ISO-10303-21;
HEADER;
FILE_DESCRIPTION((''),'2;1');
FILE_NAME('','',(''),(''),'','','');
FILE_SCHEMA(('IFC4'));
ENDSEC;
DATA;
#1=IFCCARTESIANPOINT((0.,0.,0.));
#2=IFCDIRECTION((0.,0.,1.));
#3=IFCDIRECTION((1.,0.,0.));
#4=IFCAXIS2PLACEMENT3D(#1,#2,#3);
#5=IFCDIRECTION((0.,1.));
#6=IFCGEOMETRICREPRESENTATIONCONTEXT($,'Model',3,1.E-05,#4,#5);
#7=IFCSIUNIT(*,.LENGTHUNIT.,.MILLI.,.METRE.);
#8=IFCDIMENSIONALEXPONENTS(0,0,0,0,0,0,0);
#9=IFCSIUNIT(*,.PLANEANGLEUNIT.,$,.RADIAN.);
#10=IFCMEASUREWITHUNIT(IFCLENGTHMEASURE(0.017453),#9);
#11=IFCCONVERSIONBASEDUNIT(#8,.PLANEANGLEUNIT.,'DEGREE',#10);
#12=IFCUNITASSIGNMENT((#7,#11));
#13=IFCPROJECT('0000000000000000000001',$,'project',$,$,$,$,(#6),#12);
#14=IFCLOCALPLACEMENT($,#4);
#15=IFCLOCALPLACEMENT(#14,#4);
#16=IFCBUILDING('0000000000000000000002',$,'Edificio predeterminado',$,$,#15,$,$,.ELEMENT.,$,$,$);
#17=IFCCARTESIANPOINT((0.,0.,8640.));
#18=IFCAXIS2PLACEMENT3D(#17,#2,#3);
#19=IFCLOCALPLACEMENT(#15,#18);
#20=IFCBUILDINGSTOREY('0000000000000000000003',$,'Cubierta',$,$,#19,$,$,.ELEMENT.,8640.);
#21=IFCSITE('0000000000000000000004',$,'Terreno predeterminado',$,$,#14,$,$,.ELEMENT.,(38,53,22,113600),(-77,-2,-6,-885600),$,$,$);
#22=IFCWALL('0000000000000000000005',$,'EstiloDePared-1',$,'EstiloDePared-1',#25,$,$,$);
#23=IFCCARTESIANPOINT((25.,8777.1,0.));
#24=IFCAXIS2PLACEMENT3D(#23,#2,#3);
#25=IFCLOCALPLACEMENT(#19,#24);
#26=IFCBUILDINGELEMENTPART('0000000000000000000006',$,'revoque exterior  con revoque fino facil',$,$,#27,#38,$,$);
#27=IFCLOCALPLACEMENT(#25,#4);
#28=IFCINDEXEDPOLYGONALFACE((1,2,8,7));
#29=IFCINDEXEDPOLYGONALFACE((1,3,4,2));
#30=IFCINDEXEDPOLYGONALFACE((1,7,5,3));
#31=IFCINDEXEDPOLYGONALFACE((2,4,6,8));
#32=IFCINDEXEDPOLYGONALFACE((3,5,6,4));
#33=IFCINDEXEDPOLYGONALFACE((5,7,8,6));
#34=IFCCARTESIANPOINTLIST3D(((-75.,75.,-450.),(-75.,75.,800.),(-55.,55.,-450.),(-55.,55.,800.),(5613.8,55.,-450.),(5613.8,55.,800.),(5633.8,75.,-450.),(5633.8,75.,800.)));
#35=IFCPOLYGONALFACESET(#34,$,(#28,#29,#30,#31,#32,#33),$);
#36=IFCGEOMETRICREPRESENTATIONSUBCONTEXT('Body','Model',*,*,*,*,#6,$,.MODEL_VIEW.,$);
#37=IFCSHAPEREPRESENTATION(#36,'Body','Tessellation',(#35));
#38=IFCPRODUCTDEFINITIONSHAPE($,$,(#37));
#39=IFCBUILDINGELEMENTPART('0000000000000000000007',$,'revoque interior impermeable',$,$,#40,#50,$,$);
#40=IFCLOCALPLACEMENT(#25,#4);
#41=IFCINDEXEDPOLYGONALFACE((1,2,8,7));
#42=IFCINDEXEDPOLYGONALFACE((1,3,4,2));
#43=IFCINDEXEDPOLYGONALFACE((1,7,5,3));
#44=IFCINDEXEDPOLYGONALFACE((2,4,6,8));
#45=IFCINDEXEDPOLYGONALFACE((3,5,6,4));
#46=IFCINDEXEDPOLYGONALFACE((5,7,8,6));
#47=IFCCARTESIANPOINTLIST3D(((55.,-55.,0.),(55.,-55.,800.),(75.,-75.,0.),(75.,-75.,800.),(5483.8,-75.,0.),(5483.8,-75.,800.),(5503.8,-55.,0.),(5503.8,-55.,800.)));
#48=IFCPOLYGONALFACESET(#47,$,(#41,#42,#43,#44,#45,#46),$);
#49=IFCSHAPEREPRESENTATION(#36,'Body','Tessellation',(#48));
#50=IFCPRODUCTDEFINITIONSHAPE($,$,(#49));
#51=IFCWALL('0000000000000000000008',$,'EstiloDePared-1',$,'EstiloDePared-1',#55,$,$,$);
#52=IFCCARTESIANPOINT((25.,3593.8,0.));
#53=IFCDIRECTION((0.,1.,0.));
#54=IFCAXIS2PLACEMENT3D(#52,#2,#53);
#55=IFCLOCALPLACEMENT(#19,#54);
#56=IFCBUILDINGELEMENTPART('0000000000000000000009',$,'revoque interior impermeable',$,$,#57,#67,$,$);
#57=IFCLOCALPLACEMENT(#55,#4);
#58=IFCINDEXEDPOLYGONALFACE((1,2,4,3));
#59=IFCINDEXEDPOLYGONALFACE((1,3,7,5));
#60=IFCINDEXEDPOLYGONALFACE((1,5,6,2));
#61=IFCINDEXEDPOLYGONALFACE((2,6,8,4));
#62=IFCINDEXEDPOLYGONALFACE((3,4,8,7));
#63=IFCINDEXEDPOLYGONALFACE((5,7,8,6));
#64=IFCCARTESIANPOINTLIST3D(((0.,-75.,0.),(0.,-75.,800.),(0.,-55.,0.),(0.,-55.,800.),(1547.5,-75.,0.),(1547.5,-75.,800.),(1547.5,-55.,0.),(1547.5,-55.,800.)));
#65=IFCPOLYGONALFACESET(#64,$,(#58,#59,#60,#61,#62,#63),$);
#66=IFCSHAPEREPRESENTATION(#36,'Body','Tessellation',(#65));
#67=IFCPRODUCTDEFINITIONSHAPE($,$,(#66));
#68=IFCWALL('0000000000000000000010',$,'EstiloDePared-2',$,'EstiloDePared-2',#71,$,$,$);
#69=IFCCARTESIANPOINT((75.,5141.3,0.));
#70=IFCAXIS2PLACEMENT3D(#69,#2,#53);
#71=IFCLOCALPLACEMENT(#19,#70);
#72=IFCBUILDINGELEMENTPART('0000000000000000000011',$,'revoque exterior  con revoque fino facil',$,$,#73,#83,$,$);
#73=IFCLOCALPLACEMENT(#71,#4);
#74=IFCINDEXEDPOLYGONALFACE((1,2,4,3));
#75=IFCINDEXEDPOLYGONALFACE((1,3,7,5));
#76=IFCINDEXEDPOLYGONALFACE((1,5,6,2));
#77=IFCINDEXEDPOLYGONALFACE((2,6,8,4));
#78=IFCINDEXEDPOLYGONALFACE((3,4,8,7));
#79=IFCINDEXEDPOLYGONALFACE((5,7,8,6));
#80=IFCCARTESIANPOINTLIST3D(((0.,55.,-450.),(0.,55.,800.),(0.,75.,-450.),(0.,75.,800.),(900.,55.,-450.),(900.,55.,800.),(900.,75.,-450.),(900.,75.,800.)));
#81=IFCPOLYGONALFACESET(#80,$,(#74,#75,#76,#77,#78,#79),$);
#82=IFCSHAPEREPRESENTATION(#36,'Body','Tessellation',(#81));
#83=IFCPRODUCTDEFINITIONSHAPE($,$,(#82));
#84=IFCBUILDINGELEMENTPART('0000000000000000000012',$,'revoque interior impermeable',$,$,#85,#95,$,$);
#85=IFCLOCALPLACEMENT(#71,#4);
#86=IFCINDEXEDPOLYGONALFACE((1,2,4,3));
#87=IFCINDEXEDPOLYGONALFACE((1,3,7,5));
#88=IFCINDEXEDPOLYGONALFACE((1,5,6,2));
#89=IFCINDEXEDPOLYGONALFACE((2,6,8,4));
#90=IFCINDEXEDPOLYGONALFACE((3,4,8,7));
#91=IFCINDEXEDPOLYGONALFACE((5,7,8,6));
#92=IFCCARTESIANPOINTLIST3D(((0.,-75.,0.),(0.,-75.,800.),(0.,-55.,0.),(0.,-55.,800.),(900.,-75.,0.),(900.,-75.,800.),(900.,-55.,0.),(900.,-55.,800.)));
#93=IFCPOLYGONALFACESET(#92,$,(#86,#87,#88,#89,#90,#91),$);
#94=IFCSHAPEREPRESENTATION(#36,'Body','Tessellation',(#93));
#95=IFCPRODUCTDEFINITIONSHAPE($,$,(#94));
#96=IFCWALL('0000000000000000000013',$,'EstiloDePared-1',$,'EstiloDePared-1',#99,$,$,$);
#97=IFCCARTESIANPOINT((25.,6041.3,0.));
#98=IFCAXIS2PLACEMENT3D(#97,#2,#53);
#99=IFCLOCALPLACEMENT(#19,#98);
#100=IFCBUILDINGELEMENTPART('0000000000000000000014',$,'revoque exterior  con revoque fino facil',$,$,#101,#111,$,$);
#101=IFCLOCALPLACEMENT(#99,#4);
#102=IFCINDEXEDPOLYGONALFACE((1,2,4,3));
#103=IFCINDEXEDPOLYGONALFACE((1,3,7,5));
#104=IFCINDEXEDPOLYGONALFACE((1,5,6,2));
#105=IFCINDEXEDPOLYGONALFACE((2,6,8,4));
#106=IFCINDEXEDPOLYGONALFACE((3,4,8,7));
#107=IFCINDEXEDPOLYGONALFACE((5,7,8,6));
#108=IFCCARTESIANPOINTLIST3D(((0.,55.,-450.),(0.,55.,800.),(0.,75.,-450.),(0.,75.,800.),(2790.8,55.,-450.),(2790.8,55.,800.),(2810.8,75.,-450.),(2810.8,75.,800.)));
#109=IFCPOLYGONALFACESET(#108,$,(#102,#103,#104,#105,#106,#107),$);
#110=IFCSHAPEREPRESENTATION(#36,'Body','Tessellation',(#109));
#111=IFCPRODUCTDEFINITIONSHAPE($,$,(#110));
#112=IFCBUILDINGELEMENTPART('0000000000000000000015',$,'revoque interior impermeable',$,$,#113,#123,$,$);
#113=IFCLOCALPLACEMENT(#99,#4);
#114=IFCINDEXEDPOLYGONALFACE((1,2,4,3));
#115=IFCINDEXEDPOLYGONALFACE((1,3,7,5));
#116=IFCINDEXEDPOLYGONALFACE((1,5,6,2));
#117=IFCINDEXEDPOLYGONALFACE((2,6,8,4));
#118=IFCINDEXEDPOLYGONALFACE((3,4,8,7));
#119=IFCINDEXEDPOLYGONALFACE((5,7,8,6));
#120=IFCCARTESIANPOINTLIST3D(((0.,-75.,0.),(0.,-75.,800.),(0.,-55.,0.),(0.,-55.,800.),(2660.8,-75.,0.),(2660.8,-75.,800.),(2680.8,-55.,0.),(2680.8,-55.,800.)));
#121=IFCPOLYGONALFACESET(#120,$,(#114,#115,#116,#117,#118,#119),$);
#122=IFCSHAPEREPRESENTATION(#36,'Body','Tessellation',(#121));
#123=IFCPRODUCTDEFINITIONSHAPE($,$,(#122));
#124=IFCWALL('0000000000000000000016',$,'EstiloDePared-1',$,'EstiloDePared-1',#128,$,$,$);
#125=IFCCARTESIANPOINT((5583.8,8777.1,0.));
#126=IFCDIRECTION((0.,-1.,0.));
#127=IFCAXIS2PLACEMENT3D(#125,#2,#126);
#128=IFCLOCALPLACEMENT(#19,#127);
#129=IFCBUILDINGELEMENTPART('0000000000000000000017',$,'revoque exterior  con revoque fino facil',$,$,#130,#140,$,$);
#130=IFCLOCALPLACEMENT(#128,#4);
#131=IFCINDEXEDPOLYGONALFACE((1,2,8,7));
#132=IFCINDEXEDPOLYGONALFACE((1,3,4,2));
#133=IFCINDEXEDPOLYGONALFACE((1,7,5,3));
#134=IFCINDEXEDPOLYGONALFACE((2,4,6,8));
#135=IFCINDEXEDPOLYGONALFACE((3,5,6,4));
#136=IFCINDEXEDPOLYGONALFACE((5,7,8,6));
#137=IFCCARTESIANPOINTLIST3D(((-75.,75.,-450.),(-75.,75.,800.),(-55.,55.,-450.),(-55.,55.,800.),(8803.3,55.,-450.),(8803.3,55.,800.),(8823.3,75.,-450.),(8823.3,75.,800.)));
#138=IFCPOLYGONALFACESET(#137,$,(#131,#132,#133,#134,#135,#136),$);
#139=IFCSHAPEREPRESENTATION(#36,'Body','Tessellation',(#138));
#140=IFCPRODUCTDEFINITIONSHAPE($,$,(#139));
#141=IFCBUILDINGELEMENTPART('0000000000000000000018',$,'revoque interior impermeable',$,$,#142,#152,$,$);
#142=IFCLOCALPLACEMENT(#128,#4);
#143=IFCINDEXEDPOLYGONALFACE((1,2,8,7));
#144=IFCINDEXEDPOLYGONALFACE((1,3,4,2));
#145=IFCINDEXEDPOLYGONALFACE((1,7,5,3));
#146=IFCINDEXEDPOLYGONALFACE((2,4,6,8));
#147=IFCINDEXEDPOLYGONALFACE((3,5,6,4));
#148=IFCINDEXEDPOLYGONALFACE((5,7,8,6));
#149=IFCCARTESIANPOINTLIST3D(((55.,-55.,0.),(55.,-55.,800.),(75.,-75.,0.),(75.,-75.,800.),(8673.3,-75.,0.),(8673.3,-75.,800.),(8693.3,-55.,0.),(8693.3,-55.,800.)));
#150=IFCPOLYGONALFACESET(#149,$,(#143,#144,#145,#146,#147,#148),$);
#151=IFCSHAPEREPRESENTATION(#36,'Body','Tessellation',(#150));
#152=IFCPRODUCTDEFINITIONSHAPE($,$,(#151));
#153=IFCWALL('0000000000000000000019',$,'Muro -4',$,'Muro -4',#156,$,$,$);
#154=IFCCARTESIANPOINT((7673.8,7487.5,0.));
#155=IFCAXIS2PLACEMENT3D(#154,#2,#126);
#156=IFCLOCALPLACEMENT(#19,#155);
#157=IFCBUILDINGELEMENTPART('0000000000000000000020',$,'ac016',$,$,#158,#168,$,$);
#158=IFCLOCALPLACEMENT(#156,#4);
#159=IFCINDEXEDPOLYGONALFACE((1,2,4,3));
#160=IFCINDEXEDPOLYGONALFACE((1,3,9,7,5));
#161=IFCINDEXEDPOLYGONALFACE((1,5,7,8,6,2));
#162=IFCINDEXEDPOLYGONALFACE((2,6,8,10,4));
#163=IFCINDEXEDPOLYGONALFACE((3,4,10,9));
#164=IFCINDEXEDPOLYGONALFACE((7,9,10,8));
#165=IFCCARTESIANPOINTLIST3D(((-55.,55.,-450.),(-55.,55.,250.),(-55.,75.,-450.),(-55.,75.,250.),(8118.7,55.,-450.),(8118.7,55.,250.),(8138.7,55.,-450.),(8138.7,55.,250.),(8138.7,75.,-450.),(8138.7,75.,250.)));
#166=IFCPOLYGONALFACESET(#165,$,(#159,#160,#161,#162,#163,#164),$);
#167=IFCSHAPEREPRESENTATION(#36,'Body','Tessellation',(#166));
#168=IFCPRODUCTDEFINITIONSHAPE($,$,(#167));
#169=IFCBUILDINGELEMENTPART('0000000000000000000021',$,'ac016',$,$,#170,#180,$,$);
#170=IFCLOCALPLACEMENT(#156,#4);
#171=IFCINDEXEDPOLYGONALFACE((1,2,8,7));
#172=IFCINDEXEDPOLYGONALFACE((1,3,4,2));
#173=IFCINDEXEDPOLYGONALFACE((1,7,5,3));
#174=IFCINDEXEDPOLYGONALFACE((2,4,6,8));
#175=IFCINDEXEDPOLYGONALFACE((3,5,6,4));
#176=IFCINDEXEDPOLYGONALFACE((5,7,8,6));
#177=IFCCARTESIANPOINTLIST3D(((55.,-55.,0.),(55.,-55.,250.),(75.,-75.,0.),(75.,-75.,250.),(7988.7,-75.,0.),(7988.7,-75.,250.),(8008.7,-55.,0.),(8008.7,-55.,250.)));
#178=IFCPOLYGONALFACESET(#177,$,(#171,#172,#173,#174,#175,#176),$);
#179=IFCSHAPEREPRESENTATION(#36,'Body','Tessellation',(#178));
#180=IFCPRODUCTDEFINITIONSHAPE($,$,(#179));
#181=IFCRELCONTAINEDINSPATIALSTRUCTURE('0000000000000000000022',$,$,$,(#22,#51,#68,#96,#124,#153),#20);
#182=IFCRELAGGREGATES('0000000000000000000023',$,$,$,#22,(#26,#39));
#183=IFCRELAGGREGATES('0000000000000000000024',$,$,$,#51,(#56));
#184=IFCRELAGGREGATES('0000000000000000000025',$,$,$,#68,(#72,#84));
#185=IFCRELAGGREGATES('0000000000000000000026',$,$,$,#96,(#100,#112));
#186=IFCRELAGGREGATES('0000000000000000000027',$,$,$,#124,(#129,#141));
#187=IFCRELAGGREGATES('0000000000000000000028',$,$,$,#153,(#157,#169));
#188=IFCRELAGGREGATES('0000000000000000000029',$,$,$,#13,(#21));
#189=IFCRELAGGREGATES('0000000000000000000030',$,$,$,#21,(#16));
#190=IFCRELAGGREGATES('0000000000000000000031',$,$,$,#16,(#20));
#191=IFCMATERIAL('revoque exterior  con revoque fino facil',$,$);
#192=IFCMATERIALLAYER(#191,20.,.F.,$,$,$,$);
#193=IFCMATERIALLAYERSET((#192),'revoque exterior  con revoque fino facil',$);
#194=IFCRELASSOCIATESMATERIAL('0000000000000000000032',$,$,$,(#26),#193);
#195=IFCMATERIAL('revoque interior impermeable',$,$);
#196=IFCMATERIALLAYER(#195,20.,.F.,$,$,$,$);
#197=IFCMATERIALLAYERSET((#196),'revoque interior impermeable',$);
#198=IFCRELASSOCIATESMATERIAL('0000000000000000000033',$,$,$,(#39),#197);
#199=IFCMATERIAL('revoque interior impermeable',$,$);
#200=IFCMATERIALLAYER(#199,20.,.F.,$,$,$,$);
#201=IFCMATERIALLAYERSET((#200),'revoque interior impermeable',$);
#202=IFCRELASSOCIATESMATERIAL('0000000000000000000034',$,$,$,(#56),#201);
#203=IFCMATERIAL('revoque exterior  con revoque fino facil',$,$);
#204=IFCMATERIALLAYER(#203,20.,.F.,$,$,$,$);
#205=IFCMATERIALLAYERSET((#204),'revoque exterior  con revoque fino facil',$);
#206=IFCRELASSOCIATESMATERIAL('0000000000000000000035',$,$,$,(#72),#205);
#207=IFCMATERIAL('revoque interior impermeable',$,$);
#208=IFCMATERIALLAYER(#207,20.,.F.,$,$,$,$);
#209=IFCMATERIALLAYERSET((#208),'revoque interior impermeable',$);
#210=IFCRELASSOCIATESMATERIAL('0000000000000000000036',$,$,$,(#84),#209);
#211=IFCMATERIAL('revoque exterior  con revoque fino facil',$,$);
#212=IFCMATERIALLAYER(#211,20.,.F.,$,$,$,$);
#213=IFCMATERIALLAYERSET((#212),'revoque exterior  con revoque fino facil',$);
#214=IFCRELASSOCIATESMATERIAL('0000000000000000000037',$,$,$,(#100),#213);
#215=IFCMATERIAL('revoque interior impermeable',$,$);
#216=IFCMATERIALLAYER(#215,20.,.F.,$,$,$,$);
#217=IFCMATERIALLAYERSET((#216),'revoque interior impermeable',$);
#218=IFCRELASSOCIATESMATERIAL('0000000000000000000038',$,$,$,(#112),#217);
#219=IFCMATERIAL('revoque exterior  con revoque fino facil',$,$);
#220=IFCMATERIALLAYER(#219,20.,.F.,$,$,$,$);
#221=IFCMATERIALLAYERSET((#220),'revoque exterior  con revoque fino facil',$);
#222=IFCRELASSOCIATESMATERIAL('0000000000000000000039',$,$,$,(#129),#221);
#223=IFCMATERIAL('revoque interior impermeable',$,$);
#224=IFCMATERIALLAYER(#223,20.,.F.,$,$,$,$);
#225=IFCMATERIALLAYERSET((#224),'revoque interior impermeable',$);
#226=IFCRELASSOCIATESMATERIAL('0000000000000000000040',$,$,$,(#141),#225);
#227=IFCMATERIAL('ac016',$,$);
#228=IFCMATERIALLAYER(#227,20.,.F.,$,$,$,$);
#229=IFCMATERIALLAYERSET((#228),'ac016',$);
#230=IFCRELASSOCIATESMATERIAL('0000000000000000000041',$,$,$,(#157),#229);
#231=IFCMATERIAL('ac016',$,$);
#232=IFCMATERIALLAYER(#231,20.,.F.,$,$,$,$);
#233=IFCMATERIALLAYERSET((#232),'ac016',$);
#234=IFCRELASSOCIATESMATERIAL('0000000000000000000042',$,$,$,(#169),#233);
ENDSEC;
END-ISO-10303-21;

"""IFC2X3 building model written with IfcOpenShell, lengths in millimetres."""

from ifc_helpers import new_model, entity, si_unit, converted_unit, direction, frame, origin_with_axes, place, context, subcontext, project, spatial, polyline, outline, extrude, material, layer, layer_set, layer_usage, element, aggregate, save


model = new_model("IFC2X3")

# Units and contexts
model_context = context("Model", 3, precision=1e-05, world=origin_with_axes(), true_north=direction((0.0, 1.0)))
body_context = subcontext(model_context, "Body", "Model", "MODEL_VIEW")
ifc_project = project(units=[si_unit("LENGTHUNIT", "METRE", prefix="MILLI"), converted_unit("PLANEANGLEUNIT", "DEGREE", entity("IfcLengthMeasure", 0.017453), si_unit("PLANEANGLEUNIT", "RADIAN"), dimensions=[0, 0, 0, 0, 0, 0, 0])], contexts=[model_context])

# Site, building, storey
site_placement = place(None, origin_with_axes())
site = spatial("IfcSite", under=ifc_project, at=site_placement, Name="Terreno predeterminado", CompositionType="ELEMENT", RefLatitude=(38, 53, 22, 113600), RefLongitude=(-77, -2, -6, -885600))
building_placement = place(site_placement, origin_with_axes())
building = spatial("IfcBuilding", under=site, at=building_placement, Name="Edificio predeterminado", CompositionType="ELEMENT")
storey_placement = place(building_placement, frame((0.0, 0.0, 8640.0), z_axis=(0.0, 0.0, 1.0), x_axis=(1.0, 0.0, 0.0)))
storey = spatial("IfcBuildingStorey", under=building, at=storey_placement, Name="Cubierta", CompositionType="ELEMENT", Elevation=8640.0)

# Wall, building element parts
wall_1_placement = place(storey_placement, frame((25.0, 8777.1, 0.0), z_axis=(0.0, 0.0, 1.0), x_axis=(1.0, 0.0, 0.0)))
wall_1 = element("IfcWall", 1, at=wall_1_placement, inside=storey, Name="EstiloDePared-1", ObjectType="EstiloDePared-1")
ifc_material_1 = material(Name="revoque exterior  con revoque fino facil")
ifc_layer_1 = layer(ifc_material_1, 20.0, ventilated=False)
ifc_layer_set_1 = layer_set([ifc_layer_1], Name="revoque exterior  con revoque fino facil")
ifc_layer_usage_1 = layer_usage(ifc_layer_set_1, "AXIS2", "NEGATIVE", -75.0)
building_element_part_1_placement = place(wall_1_placement, origin_with_axes())
building_element_part_1 = element("IfcBuildingElementPart", 2, at=building_element_part_1_placement, material=ifc_layer_usage_1, Name="revoque exterior  con revoque fino facil", context=body_context, shape_type="SweptSolid", body=[
    extrude(outline(polyline([(5633.8, 75.0), (5613.8, 55.0), (-55.0, 55.0), (-75.0, 75.0), (5633.8, 75.0)])), frame((0.0, 0.0, -450.0), z_axis=(0.0, 0.0, 1.0), x_axis=(1.0, 0.0, 0.0)), (0.0, 0.0, 1.0), 1250.0),
])
ifc_material_2 = material(Name="revoque interior impermeable")
ifc_layer_2 = layer(ifc_material_2, 20.0, ventilated=False)
ifc_layer_set_2 = layer_set([ifc_layer_2], Name="revoque interior impermeable")
ifc_layer_usage_2 = layer_usage(ifc_layer_set_2, "AXIS2", "NEGATIVE", 55.0)
building_element_part_2_placement = place(wall_1_placement, origin_with_axes())
building_element_part_2 = element("IfcBuildingElementPart", 3, at=building_element_part_2_placement, material=ifc_layer_usage_2, Name="revoque interior impermeable", context=body_context, shape_type="SweptSolid", body=[
    extrude(outline(polyline([(5503.8, -55.0), (5483.8, -75.0), (75.0, -75.0), (55.0, -55.0), (5503.8, -55.0)])), origin_with_axes(), (0.0, 0.0, 1.0), 800.0),
])
aggregate(wall_1, [building_element_part_1, building_element_part_2])

# Wall, building element part
wall_2_placement = place(storey_placement, frame((25.0, 3593.8, 0.0), z_axis=(0.0, 0.0, 1.0), x_axis=(0.0, 1.0, 0.0)))
wall_2 = element("IfcWall", 4, at=wall_2_placement, inside=storey, Name="EstiloDePared-1", ObjectType="EstiloDePared-1")
ifc_material_3 = material(Name="revoque interior impermeable")
ifc_layer_3 = layer(ifc_material_3, 20.0, ventilated=False)
ifc_layer_set_3 = layer_set([ifc_layer_3], Name="revoque interior impermeable")
ifc_layer_usage_3 = layer_usage(ifc_layer_set_3, "AXIS2", "NEGATIVE", 55.0)
building_element_part_3_placement = place(wall_2_placement, origin_with_axes())
building_element_part_3 = element("IfcBuildingElementPart", 5, at=building_element_part_3_placement, material=ifc_layer_usage_3, Name="revoque interior impermeable", context=body_context, shape_type="SweptSolid", body=[
    extrude(outline(polyline([(1547.5, -55.0), (1547.5, -75.0), (0.0, -75.0), (0.0, -55.0), (1547.5, -55.0)])), origin_with_axes(), (0.0, 0.0, 1.0), 800.0),
])
aggregate(wall_2, [building_element_part_3])

# Walls, building element parts
wall_3_placement = place(storey_placement, frame((75.0, 5141.3, 0.0), z_axis=(0.0, 0.0, 1.0), x_axis=(0.0, 1.0, 0.0)))
wall_3 = element("IfcWall", 6, at=wall_3_placement, inside=storey, Name="EstiloDePared-2", ObjectType="EstiloDePared-2")
ifc_material_4 = material(Name="revoque exterior  con revoque fino facil")
ifc_layer_4 = layer(ifc_material_4, 20.0, ventilated=False)
ifc_layer_set_4 = layer_set([ifc_layer_4], Name="revoque exterior  con revoque fino facil")
ifc_layer_usage_4 = layer_usage(ifc_layer_set_4, "AXIS2", "NEGATIVE", -75.0)
building_element_part_4_placement = place(wall_3_placement, origin_with_axes())
building_element_part_4 = element("IfcBuildingElementPart", 7, at=building_element_part_4_placement, material=ifc_layer_usage_4, Name="revoque exterior  con revoque fino facil", context=body_context, shape_type="SweptSolid", body=[
    extrude(outline(polyline([(900.0, 75.0), (900.0, 55.0), (0.0, 55.0), (0.0, 75.0), (900.0, 75.0)])), frame((0.0, 0.0, -450.0), z_axis=(0.0, 0.0, 1.0), x_axis=(1.0, 0.0, 0.0)), (0.0, 0.0, 1.0), 1250.0),
])
ifc_material_5 = material(Name="revoque interior impermeable")
ifc_layer_5 = layer(ifc_material_5, 20.0, ventilated=False)
ifc_layer_set_5 = layer_set([ifc_layer_5], Name="revoque interior impermeable")
ifc_layer_usage_5 = layer_usage(ifc_layer_set_5, "AXIS2", "NEGATIVE", 55.0)
building_element_part_5_placement = place(wall_3_placement, origin_with_axes())
building_element_part_5 = element("IfcBuildingElementPart", 8, at=building_element_part_5_placement, material=ifc_layer_usage_5, Name="revoque interior impermeable", context=body_context, shape_type="SweptSolid", body=[
    extrude(outline(polyline([(900.0, -55.0), (900.0, -75.0), (0.0, -75.0), (0.0, -55.0), (900.0, -55.0)])), origin_with_axes(), (0.0, 0.0, 1.0), 800.0),
])
aggregate(wall_3, [building_element_part_4, building_element_part_5])
wall_4_placement = place(storey_placement, frame((25.0, 6041.3, 0.0), z_axis=(0.0, 0.0, 1.0), x_axis=(0.0, 1.0, 0.0)))
wall_4 = element("IfcWall", 9, at=wall_4_placement, inside=storey, Name="EstiloDePared-1", ObjectType="EstiloDePared-1")
ifc_material_6 = material(Name="revoque exterior  con revoque fino facil")
ifc_layer_6 = layer(ifc_material_6, 20.0, ventilated=False)
ifc_layer_set_6 = layer_set([ifc_layer_6], Name="revoque exterior  con revoque fino facil")
ifc_layer_usage_6 = layer_usage(ifc_layer_set_6, "AXIS2", "NEGATIVE", -75.0)
building_element_part_6_placement = place(wall_4_placement, origin_with_axes())
building_element_part_6 = element("IfcBuildingElementPart", 10, at=building_element_part_6_placement, material=ifc_layer_usage_6, Name="revoque exterior  con revoque fino facil", context=body_context, shape_type="SweptSolid", body=[
    extrude(outline(polyline([(2810.8, 75.0), (2790.8, 55.0), (0.0, 55.0), (0.0, 75.0), (2810.8, 75.0)])), frame((0.0, 0.0, -450.0), z_axis=(0.0, 0.0, 1.0), x_axis=(1.0, 0.0, 0.0)), (0.0, 0.0, 1.0), 1250.0),
])
ifc_material_7 = material(Name="revoque interior impermeable")
ifc_layer_7 = layer(ifc_material_7, 20.0, ventilated=False)
ifc_layer_set_7 = layer_set([ifc_layer_7], Name="revoque interior impermeable")
ifc_layer_usage_7 = layer_usage(ifc_layer_set_7, "AXIS2", "NEGATIVE", 55.0)
building_element_part_7_placement = place(wall_4_placement, origin_with_axes())
building_element_part_7 = element("IfcBuildingElementPart", 11, at=building_element_part_7_placement, material=ifc_layer_usage_7, Name="revoque interior impermeable", context=body_context, shape_type="SweptSolid", body=[
    extrude(outline(polyline([(2680.8, -55.0), (2660.8, -75.0), (0.0, -75.0), (0.0, -55.0), (2680.8, -55.0)])), origin_with_axes(), (0.0, 0.0, 1.0), 800.0),
])
aggregate(wall_4, [building_element_part_6, building_element_part_7])
wall_5_placement = place(storey_placement, frame((5583.8, 8777.1, 0.0), z_axis=(0.0, 0.0, 1.0), x_axis=(0.0, -1.0, 0.0)))
wall_5 = element("IfcWall", 12, at=wall_5_placement, inside=storey, Name="EstiloDePared-1", ObjectType="EstiloDePared-1")
ifc_material_8 = material(Name="revoque exterior  con revoque fino facil")
ifc_layer_8 = layer(ifc_material_8, 20.0, ventilated=False)
ifc_layer_set_8 = layer_set([ifc_layer_8], Name="revoque exterior  con revoque fino facil")
ifc_layer_usage_8 = layer_usage(ifc_layer_set_8, "AXIS2", "NEGATIVE", -75.0)
building_element_part_8_placement = place(wall_5_placement, origin_with_axes())
building_element_part_8 = element("IfcBuildingElementPart", 13, at=building_element_part_8_placement, material=ifc_layer_usage_8, Name="revoque exterior  con revoque fino facil", context=body_context, shape_type="SweptSolid", body=[
    extrude(outline(polyline([(8823.3, 75.0), (8803.3, 55.0), (-55.0, 55.0), (-75.0, 75.0), (8823.3, 75.0)])), frame((0.0, 0.0, -450.0), z_axis=(0.0, 0.0, 1.0), x_axis=(1.0, 0.0, 0.0)), (0.0, 0.0, 1.0), 1250.0),
])
ifc_material_9 = material(Name="revoque interior impermeable")
ifc_layer_9 = layer(ifc_material_9, 20.0, ventilated=False)
ifc_layer_set_9 = layer_set([ifc_layer_9], Name="revoque interior impermeable")
ifc_layer_usage_9 = layer_usage(ifc_layer_set_9, "AXIS2", "NEGATIVE", 55.0)
building_element_part_9_placement = place(wall_5_placement, origin_with_axes())
building_element_part_9 = element("IfcBuildingElementPart", 14, at=building_element_part_9_placement, material=ifc_layer_usage_9, Name="revoque interior impermeable", context=body_context, shape_type="SweptSolid", body=[
    extrude(outline(polyline([(8693.3, -55.0), (8673.3, -75.0), (75.0, -75.0), (55.0, -55.0), (8693.3, -55.0)])), origin_with_axes(), (0.0, 0.0, 1.0), 800.0),
])
aggregate(wall_5, [building_element_part_8, building_element_part_9])
wall_6_placement = place(storey_placement, frame((7673.8, 7487.5, 0.0), z_axis=(0.0, 0.0, 1.0), x_axis=(0.0, -1.0, 0.0)))
wall_6 = element("IfcWall", 15, at=wall_6_placement, inside=storey, Name="Muro -4", ObjectType="Muro -4")
ifc_material_10 = material(Name="ac016")
ifc_layer_10 = layer(ifc_material_10, 20.0, ventilated=False)
ifc_layer_set_10 = layer_set([ifc_layer_10], Name="ac016")
ifc_layer_usage_10 = layer_usage(ifc_layer_set_10, "AXIS2", "NEGATIVE", -75.0)
building_element_part_10_placement = place(wall_6_placement, origin_with_axes())
building_element_part_10 = element("IfcBuildingElementPart", 16, at=building_element_part_10_placement, material=ifc_layer_usage_10, Name="ac016", context=body_context, shape_type="SweptSolid", body=[
    extrude(outline(polyline([(8138.7, 75.0), (8138.7, 55.0), (8118.7, 55.0), (-55.0, 55.0), (-55.0, 75.0), (8138.7, 75.0)])), frame((0.0, 0.0, -450.0), z_axis=(0.0, 0.0, 1.0), x_axis=(1.0, 0.0, 0.0)), (0.0, 0.0, 1.0), 700.0),
])
ifc_material_11 = material(Name="ac016")
ifc_layer_11 = layer(ifc_material_11, 20.0, ventilated=False)
ifc_layer_set_11 = layer_set([ifc_layer_11], Name="ac016")
ifc_layer_usage_11 = layer_usage(ifc_layer_set_11, "AXIS2", "NEGATIVE", 55.0)
building_element_part_11_placement = place(wall_6_placement, origin_with_axes())
building_element_part_11 = element("IfcBuildingElementPart", 17, at=building_element_part_11_placement, material=ifc_layer_usage_11, Name="ac016", context=body_context, shape_type="SweptSolid", body=[
    extrude(outline(polyline([(8008.7, -55.0), (7988.7, -75.0), (75.0, -75.0), (55.0, -55.0), (8008.7, -55.0)])), origin_with_axes(), (0.0, 0.0, 1.0), 250.0),
])
aggregate(wall_6, [building_element_part_10, building_element_part_11])

save(model, "model.ifc")
